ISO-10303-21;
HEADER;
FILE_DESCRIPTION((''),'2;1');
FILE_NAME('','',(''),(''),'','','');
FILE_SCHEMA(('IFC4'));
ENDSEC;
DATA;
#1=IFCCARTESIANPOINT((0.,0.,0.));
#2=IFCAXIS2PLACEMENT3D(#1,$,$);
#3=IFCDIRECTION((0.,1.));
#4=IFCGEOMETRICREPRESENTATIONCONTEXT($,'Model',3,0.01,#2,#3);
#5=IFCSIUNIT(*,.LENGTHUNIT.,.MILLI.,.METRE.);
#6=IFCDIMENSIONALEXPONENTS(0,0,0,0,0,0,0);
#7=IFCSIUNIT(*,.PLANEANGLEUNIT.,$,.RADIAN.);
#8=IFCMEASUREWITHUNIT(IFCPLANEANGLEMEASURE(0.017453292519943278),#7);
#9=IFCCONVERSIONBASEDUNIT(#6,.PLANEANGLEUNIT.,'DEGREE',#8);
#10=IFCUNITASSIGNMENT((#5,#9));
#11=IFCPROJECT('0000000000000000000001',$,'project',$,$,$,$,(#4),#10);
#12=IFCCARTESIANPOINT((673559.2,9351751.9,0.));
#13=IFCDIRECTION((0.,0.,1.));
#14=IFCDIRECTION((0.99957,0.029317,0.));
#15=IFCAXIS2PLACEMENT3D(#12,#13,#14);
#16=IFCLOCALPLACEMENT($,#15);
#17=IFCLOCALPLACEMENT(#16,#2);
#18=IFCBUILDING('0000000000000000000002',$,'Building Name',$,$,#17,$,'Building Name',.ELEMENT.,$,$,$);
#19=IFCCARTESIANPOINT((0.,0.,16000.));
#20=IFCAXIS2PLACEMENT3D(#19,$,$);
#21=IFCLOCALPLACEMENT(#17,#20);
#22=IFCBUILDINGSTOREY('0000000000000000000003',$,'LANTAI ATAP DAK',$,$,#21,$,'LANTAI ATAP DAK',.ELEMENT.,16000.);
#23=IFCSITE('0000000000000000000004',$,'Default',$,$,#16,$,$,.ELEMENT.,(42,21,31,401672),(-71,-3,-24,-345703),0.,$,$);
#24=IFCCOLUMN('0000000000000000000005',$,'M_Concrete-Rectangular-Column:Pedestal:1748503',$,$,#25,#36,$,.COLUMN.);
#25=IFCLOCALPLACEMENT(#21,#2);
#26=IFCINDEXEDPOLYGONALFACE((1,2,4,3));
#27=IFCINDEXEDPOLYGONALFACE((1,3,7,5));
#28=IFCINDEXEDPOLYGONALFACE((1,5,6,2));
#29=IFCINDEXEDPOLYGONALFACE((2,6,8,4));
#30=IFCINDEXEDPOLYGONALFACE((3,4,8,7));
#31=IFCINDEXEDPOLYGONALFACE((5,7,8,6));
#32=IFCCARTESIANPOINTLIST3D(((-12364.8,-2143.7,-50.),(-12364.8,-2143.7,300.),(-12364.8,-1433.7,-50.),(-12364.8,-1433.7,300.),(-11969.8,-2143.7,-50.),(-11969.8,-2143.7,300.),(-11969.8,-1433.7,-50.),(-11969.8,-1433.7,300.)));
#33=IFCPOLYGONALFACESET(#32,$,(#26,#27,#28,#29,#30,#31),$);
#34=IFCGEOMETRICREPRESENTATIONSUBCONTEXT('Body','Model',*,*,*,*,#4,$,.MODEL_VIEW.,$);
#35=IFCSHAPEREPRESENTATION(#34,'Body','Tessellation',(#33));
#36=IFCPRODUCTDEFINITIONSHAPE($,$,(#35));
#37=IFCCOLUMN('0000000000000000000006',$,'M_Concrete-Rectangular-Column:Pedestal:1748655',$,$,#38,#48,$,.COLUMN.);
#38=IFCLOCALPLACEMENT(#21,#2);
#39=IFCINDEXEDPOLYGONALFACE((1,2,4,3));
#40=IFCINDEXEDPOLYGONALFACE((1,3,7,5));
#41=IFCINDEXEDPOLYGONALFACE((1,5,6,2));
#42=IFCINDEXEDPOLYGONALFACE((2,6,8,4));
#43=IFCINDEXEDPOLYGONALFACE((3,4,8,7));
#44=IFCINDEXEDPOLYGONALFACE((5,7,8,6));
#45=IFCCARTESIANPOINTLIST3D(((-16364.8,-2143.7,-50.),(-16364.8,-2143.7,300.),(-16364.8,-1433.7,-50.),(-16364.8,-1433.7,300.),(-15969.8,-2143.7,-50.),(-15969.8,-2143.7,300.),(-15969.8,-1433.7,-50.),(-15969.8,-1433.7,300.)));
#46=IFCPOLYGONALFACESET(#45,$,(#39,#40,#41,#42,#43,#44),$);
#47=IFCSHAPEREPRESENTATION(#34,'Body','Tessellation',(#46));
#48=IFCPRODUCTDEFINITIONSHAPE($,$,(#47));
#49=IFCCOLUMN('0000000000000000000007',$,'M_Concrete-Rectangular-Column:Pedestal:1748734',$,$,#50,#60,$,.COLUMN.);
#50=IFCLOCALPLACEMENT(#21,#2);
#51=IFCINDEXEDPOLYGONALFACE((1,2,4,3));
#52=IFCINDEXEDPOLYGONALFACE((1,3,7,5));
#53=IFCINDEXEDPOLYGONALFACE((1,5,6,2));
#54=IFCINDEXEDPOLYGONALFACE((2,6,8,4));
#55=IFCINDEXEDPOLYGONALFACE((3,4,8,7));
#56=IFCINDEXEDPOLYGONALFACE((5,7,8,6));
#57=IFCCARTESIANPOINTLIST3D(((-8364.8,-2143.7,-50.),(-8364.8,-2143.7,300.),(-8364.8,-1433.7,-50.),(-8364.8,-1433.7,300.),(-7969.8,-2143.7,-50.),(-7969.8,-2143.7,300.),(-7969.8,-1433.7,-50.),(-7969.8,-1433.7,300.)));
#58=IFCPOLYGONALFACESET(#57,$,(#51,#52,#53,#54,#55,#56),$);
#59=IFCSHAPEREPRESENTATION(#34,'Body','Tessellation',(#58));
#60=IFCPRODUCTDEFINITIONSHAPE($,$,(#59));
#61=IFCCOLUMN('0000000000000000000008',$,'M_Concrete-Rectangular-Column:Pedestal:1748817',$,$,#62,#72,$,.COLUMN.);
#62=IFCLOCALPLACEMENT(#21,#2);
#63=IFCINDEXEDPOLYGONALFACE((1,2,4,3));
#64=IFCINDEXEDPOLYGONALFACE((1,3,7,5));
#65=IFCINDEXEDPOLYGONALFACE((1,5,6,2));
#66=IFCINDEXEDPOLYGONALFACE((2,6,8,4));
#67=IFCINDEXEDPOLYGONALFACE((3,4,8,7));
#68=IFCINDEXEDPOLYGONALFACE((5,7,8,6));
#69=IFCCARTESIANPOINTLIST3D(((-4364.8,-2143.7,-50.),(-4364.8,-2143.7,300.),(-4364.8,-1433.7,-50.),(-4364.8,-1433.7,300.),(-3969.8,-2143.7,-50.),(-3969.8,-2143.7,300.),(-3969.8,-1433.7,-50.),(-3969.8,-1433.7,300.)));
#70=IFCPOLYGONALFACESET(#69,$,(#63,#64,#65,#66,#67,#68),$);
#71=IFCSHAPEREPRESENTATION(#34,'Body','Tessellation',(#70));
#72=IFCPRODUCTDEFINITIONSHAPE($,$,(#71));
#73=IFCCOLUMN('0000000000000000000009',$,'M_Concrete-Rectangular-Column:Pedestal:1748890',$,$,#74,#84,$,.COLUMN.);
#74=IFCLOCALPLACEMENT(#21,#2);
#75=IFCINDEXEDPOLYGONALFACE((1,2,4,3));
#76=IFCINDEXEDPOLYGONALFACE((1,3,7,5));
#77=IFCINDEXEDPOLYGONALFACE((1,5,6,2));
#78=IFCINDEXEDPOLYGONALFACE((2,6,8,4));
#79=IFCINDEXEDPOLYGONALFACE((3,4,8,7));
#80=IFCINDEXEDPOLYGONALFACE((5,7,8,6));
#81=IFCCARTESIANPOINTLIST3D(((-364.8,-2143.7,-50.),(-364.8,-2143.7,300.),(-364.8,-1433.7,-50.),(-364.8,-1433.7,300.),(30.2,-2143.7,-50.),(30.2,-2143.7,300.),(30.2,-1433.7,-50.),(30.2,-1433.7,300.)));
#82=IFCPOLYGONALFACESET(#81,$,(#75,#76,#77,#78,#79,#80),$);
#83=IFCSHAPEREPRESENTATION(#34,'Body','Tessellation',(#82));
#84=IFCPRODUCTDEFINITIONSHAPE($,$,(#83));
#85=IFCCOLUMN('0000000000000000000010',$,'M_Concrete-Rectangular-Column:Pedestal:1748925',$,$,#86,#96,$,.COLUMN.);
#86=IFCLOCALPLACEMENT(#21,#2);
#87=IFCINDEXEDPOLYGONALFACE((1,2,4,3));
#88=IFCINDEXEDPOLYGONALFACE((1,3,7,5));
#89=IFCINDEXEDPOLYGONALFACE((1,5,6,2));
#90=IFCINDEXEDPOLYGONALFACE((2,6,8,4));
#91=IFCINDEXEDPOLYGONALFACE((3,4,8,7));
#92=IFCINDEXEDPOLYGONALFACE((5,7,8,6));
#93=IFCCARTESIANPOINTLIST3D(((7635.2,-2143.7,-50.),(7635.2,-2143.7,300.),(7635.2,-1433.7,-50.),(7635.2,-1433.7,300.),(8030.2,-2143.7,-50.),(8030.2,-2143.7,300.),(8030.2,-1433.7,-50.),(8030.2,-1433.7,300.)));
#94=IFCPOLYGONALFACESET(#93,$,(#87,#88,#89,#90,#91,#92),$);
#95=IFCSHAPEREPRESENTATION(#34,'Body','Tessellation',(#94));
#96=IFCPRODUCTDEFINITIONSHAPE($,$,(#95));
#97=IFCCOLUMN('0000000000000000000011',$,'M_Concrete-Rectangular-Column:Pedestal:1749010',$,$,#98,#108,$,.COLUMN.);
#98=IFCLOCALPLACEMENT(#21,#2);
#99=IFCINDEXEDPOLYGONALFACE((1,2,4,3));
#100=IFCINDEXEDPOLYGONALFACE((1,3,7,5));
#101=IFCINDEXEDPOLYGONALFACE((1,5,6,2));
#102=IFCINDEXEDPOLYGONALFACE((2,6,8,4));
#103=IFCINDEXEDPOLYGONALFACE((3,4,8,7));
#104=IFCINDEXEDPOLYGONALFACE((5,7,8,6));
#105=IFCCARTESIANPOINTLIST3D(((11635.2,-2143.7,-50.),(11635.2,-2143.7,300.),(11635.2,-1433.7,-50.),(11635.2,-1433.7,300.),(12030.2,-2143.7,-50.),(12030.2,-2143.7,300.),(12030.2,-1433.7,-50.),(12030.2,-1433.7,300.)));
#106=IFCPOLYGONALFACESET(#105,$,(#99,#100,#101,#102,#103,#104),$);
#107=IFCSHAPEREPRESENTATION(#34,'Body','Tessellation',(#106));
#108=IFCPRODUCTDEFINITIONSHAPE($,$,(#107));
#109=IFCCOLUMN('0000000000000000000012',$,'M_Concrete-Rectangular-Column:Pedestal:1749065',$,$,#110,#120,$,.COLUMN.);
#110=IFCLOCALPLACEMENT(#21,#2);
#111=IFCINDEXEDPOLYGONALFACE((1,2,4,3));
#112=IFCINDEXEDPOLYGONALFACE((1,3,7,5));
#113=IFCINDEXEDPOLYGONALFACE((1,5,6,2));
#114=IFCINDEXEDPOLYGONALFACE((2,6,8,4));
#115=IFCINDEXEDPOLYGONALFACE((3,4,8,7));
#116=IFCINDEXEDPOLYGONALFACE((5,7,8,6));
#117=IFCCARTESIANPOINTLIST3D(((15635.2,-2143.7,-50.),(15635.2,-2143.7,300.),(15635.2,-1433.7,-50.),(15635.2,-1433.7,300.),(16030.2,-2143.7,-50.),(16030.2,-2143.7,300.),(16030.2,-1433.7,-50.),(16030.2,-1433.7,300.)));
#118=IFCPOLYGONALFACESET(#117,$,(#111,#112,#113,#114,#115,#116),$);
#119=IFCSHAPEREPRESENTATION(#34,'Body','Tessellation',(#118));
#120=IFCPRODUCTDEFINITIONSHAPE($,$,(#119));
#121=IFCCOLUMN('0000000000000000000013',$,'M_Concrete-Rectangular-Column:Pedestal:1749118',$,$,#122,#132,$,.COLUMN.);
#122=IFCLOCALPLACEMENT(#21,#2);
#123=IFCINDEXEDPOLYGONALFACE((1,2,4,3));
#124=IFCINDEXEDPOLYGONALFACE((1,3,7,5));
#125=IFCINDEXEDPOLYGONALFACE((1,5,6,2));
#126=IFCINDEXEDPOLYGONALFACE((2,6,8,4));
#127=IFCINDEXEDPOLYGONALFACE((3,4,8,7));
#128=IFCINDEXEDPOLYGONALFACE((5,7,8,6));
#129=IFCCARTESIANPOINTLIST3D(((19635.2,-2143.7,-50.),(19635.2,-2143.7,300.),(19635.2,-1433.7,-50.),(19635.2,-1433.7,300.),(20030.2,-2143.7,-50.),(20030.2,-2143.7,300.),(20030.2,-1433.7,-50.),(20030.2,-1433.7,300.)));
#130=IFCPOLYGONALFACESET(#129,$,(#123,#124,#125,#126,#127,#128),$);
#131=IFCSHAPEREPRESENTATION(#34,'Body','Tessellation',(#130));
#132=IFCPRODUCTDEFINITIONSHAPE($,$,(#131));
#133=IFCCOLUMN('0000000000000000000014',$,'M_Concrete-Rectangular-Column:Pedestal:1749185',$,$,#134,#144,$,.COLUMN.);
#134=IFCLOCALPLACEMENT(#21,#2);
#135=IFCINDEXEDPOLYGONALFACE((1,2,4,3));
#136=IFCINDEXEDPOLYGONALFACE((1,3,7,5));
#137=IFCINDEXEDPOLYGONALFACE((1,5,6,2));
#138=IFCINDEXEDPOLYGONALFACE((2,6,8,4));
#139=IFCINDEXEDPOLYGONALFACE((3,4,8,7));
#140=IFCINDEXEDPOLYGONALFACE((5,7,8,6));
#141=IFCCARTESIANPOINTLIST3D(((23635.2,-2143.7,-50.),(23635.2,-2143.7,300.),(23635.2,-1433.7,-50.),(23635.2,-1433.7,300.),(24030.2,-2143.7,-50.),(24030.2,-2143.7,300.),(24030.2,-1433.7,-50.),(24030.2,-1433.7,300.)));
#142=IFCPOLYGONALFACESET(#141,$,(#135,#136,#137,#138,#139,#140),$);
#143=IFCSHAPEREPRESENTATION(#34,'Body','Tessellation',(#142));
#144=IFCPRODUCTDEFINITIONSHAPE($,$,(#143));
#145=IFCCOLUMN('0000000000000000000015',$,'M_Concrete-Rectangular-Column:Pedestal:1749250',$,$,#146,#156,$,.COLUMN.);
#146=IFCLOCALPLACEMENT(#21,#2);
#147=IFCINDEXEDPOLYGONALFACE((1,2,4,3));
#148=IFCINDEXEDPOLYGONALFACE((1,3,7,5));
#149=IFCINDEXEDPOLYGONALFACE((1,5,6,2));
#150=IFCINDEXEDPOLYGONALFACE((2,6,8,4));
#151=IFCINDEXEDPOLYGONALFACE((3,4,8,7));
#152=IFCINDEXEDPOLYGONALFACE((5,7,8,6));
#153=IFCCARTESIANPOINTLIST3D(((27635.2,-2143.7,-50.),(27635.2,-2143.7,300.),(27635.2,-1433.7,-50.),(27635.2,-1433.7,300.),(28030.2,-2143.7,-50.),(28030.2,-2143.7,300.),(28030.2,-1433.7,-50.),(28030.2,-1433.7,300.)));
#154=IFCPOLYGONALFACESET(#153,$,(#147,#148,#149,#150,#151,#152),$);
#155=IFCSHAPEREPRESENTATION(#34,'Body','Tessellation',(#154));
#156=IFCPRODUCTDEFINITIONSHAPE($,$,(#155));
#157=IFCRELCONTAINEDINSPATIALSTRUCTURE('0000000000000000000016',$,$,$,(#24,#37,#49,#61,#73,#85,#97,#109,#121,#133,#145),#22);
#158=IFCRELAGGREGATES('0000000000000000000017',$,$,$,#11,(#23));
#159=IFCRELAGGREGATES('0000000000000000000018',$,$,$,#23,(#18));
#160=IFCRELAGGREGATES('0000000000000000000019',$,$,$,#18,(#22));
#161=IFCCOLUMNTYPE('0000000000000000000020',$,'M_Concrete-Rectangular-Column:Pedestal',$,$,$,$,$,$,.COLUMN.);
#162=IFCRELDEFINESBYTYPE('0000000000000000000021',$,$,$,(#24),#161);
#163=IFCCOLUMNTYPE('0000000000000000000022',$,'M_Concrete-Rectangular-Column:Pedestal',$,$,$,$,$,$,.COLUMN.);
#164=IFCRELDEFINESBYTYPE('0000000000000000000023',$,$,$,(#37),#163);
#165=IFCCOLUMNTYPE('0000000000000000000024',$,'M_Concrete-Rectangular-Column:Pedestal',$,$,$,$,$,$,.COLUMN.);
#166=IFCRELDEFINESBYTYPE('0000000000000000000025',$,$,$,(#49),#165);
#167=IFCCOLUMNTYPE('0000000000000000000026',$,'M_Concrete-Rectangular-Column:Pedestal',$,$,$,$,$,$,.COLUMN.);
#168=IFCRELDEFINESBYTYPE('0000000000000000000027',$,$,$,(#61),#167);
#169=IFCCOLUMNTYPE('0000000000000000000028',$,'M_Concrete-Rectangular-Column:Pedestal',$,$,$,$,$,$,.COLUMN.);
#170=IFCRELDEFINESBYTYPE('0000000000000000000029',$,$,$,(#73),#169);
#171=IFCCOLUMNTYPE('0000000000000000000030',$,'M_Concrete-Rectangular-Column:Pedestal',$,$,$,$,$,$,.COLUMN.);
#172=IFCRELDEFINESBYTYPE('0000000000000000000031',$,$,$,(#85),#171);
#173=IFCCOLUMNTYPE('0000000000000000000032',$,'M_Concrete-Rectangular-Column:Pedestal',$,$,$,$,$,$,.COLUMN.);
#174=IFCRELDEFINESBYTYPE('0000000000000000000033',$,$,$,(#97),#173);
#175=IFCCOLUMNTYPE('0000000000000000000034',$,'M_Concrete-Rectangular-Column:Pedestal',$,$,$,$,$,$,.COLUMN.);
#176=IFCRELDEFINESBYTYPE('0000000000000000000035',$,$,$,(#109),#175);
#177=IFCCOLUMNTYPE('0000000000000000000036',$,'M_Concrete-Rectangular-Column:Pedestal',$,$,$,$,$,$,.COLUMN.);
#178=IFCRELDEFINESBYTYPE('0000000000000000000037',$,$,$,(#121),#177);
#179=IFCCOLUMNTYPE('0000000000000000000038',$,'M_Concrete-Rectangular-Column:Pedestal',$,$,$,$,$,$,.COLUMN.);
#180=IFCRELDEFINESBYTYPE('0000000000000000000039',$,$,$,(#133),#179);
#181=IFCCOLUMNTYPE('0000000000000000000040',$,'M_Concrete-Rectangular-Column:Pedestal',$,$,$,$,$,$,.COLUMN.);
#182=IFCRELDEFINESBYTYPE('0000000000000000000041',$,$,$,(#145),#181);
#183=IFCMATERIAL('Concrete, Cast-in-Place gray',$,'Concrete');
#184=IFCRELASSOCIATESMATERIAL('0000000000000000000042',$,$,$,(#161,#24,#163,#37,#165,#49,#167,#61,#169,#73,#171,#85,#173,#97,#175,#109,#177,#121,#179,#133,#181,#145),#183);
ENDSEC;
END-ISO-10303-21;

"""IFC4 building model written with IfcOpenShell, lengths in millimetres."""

from ifc_helpers import new_model, entity, si_unit, converted_unit, direction, frame, origin, place, context, subcontext, project, spatial, indexed_curve, outline, extrude, source, transform, mapped, material, type_object, type_shapes, element, save


model = new_model("IFC4")

# Units and contexts
model_context = context("Model", 3, precision=0.01, world=origin(), true_north=direction((0.0, 1.0)))
body_context = subcontext(model_context, "Body", "Model", "MODEL_VIEW")
ifc_project = project(units=[si_unit("LENGTHUNIT", "METRE", prefix="MILLI"), converted_unit("PLANEANGLEUNIT", "DEGREE", entity("IfcPlaneAngleMeasure", 0.017453292519943278), si_unit("PLANEANGLEUNIT", "RADIAN"), dimensions=[0, 0, 0, 0, 0, 0, 0])], contexts=[model_context])

# Site, building, storey
site_placement = place(None, frame((673559.2, 9351751.9, 0.0), z_axis=(0.0, 0.0, 1.0), x_axis=(0.99957, 0.029317, 0.0)))
site = spatial("IfcSite", under=ifc_project, at=site_placement, Name="Default", CompositionType="ELEMENT", RefLatitude=(42, 21, 31, 401672), RefLongitude=(-71, -3, -24, -345703), RefElevation=0.0)
building_placement = place(site_placement, origin())
building = spatial("IfcBuilding", under=site, at=building_placement, Name="Building Name", LongName="Building Name", CompositionType="ELEMENT")
storey_placement = place(building_placement, frame((0.0, 0.0, 16000.0)))
storey = spatial("IfcBuildingStorey", under=building, at=storey_placement, Name="LANTAI ATAP DAK", LongName="LANTAI ATAP DAK", CompositionType="ELEMENT", Elevation=16000.0)

# Columns
ifc_material = material(Name="Concrete, Cast-in-Place gray", Category="Concrete")
column_type_1 = type_object("IfcColumnType", Name="M_Concrete-Rectangular-Column:Pedestal", PredefinedType="COLUMN", material=ifc_material)
shared_shape_1 = source(origin(), body_context, "Body", "SweptSolid", [
    extrude(outline(indexed_curve([(-197.5, -355.0), (197.5, -355.0), (197.5, 355.0), (-197.5, 355.0), (-197.5, -355.0)], self_intersect=False)), frame((-12167.3, -1788.7, 15950.0), z_axis=(0.0, 0.0, 1.0), x_axis=(-1.0, 0.0, 0.0)), (0.0, 0.0, 1.0), 350.0),
])
type_shapes(column_type_1, [shared_shape_1])
column_1_placement = place(storey_placement, frame((0.0, 0.0, -16000.0)))
element("IfcColumn", 1, at=column_1_placement, inside=storey, type_object=column_type_1, material=ifc_material, Name="M_Concrete-Rectangular-Column:Pedestal:1748503", PredefinedType="COLUMN", context=body_context, shape_type="MappedRepresentation", body=[
    mapped(shared_shape_1, transform((0.0, 0.0, 0.0), scale=1.0)),
])
column_type_2 = type_object("IfcColumnType", Name="M_Concrete-Rectangular-Column:Pedestal", PredefinedType="COLUMN", material=ifc_material)
shared_shape_2 = source(origin(), body_context, "Body", "SweptSolid", [
    extrude(outline(indexed_curve([(-197.5, -355.0), (197.5, -355.0), (197.5, 355.0), (-197.5, 355.0), (-197.5, -355.0)], self_intersect=False)), frame((-16167.3, -1788.7, 15950.0), z_axis=(0.0, 0.0, 1.0), x_axis=(-1.0, 0.0, 0.0)), (0.0, 0.0, 1.0), 350.0),
])
type_shapes(column_type_2, [shared_shape_2])
column_2_placement = place(storey_placement, frame((0.0, 0.0, -16000.0)))
element("IfcColumn", 2, at=column_2_placement, inside=storey, type_object=column_type_2, material=ifc_material, Name="M_Concrete-Rectangular-Column:Pedestal:1748655", PredefinedType="COLUMN", context=body_context, shape_type="MappedRepresentation", body=[
    mapped(shared_shape_2, transform((0.0, 0.0, 0.0), scale=1.0)),
])
column_type_3 = type_object("IfcColumnType", Name="M_Concrete-Rectangular-Column:Pedestal", PredefinedType="COLUMN", material=ifc_material)
shared_shape_3 = source(origin(), body_context, "Body", "SweptSolid", [
    extrude(outline(indexed_curve([(-197.5, -355.0), (197.5, -355.0), (197.5, 355.0), (-197.5, 355.0), (-197.5, -355.0)], self_intersect=False)), frame((-8167.3, -1788.7, 15950.0), z_axis=(0.0, 0.0, 1.0), x_axis=(-1.0, 0.0, 0.0)), (0.0, 0.0, 1.0), 350.0),
])
type_shapes(column_type_3, [shared_shape_3])
column_3_placement = place(storey_placement, frame((0.0, 0.0, -16000.0)))
element("IfcColumn", 3, at=column_3_placement, inside=storey, type_object=column_type_3, material=ifc_material, Name="M_Concrete-Rectangular-Column:Pedestal:1748734", PredefinedType="COLUMN", context=body_context, shape_type="MappedRepresentation", body=[
    mapped(shared_shape_3, transform((0.0, 0.0, 0.0), scale=1.0)),
])
column_type_4 = type_object("IfcColumnType", Name="M_Concrete-Rectangular-Column:Pedestal", PredefinedType="COLUMN", material=ifc_material)
shared_shape_4 = source(origin(), body_context, "Body", "SweptSolid", [
    extrude(outline(indexed_curve([(-197.5, -355.0), (197.5, -355.0), (197.5, 355.0), (-197.5, 355.0), (-197.5, -355.0)], self_intersect=False)), frame((-4167.3, -1788.7, 15950.0), z_axis=(0.0, 0.0, 1.0), x_axis=(-1.0, 0.0, 0.0)), (0.0, 0.0, 1.0), 350.0),
])
type_shapes(column_type_4, [shared_shape_4])
column_4_placement = place(storey_placement, frame((0.0, 0.0, -16000.0)))
element("IfcColumn", 4, at=column_4_placement, inside=storey, type_object=column_type_4, material=ifc_material, Name="M_Concrete-Rectangular-Column:Pedestal:1748817", PredefinedType="COLUMN", context=body_context, shape_type="MappedRepresentation", body=[
    mapped(shared_shape_4, transform((0.0, 0.0, 0.0), scale=1.0)),
])
column_type_5 = type_object("IfcColumnType", Name="M_Concrete-Rectangular-Column:Pedestal", PredefinedType="COLUMN", material=ifc_material)
shared_shape_5 = source(origin(), body_context, "Body", "SweptSolid", [
    extrude(outline(indexed_curve([(-197.5, -355.0), (197.5, -355.0), (197.5, 355.0), (-197.5, 355.0), (-197.5, -355.0)], self_intersect=False)), frame((-167.3, -1788.7, 15950.0), z_axis=(0.0, 0.0, 1.0), x_axis=(-1.0, 0.0, 0.0)), (0.0, 0.0, 1.0), 350.0),
])
type_shapes(column_type_5, [shared_shape_5])
column_5_placement = place(storey_placement, frame((0.0, 0.0, -16000.0)))
element("IfcColumn", 5, at=column_5_placement, inside=storey, type_object=column_type_5, material=ifc_material, Name="M_Concrete-Rectangular-Column:Pedestal:1748890", PredefinedType="COLUMN", context=body_context, shape_type="MappedRepresentation", body=[
    mapped(shared_shape_5, transform((0.0, 0.0, 0.0), scale=1.0)),
])
column_type_6 = type_object("IfcColumnType", Name="M_Concrete-Rectangular-Column:Pedestal", PredefinedType="COLUMN", material=ifc_material)
shared_shape_6 = source(origin(), body_context, "Body", "SweptSolid", [
    extrude(outline(indexed_curve([(-197.5, -355.0), (197.5, -355.0), (197.5, 355.0), (-197.5, 355.0), (-197.5, -355.0)], self_intersect=False)), frame((7832.7, -1788.7, 15950.0), z_axis=(0.0, 0.0, 1.0), x_axis=(-1.0, 0.0, 0.0)), (0.0, 0.0, 1.0), 350.0),
])
type_shapes(column_type_6, [shared_shape_6])
column_6_placement = place(storey_placement, frame((0.0, 0.0, -16000.0)))
element("IfcColumn", 6, at=column_6_placement, inside=storey, type_object=column_type_6, material=ifc_material, Name="M_Concrete-Rectangular-Column:Pedestal:1748925", PredefinedType="COLUMN", context=body_context, shape_type="MappedRepresentation", body=[
    mapped(shared_shape_6, transform((0.0, 0.0, 0.0), scale=1.0)),
])
column_type_7 = type_object("IfcColumnType", Name="M_Concrete-Rectangular-Column:Pedestal", PredefinedType="COLUMN", material=ifc_material)
shared_shape_7 = source(origin(), body_context, "Body", "SweptSolid", [
    extrude(outline(indexed_curve([(-197.5, -355.0), (197.5, -355.0), (197.5, 355.0), (-197.5, 355.0), (-197.5, -355.0)], self_intersect=False)), frame((11832.7, -1788.7, 15950.0), z_axis=(0.0, 0.0, 1.0), x_axis=(-1.0, 0.0, 0.0)), (0.0, 0.0, 1.0), 350.0),
])
type_shapes(column_type_7, [shared_shape_7])
column_7_placement = place(storey_placement, frame((0.0, 0.0, -16000.0)))
element("IfcColumn", 7, at=column_7_placement, inside=storey, type_object=column_type_7, material=ifc_material, Name="M_Concrete-Rectangular-Column:Pedestal:1749010", PredefinedType="COLUMN", context=body_context, shape_type="MappedRepresentation", body=[
    mapped(shared_shape_7, transform((0.0, 0.0, 0.0), scale=1.0)),
])
column_type_8 = type_object("IfcColumnType", Name="M_Concrete-Rectangular-Column:Pedestal", PredefinedType="COLUMN", material=ifc_material)
shared_shape_8 = source(origin(), body_context, "Body", "SweptSolid", [
    extrude(outline(indexed_curve([(-197.5, -355.0), (197.5, -355.0), (197.5, 355.0), (-197.5, 355.0), (-197.5, -355.0)], self_intersect=False)), frame((15832.7, -1788.7, 15950.0), z_axis=(0.0, 0.0, 1.0), x_axis=(-1.0, 0.0, 0.0)), (0.0, 0.0, 1.0), 350.0),
])
type_shapes(column_type_8, [shared_shape_8])
column_8_placement = place(storey_placement, frame((0.0, 0.0, -16000.0)))
element("IfcColumn", 8, at=column_8_placement, inside=storey, type_object=column_type_8, material=ifc_material, Name="M_Concrete-Rectangular-Column:Pedestal:1749065", PredefinedType="COLUMN", context=body_context, shape_type="MappedRepresentation", body=[
    mapped(shared_shape_8, transform((0.0, 0.0, 0.0), scale=1.0)),
])
column_type_9 = type_object("IfcColumnType", Name="M_Concrete-Rectangular-Column:Pedestal", PredefinedType="COLUMN", material=ifc_material)
shared_shape_9 = source(origin(), body_context, "Body", "SweptSolid", [
    extrude(outline(indexed_curve([(-197.5, -355.0), (197.5, -355.0), (197.5, 355.0), (-197.5, 355.0), (-197.5, -355.0)], self_intersect=False)), frame((19832.7, -1788.7, 15950.0), z_axis=(0.0, 0.0, 1.0), x_axis=(-1.0, 0.0, 0.0)), (0.0, 0.0, 1.0), 350.0),
])
type_shapes(column_type_9, [shared_shape_9])
column_9_placement = place(storey_placement, frame((0.0, 0.0, -16000.0)))
element("IfcColumn", 9, at=column_9_placement, inside=storey, type_object=column_type_9, material=ifc_material, Name="M_Concrete-Rectangular-Column:Pedestal:1749118", PredefinedType="COLUMN", context=body_context, shape_type="MappedRepresentation", body=[
    mapped(shared_shape_9, transform((0.0, 0.0, 0.0), scale=1.0)),
])
column_type_10 = type_object("IfcColumnType", Name="M_Concrete-Rectangular-Column:Pedestal", PredefinedType="COLUMN", material=ifc_material)
shared_shape_10 = source(origin(), body_context, "Body", "SweptSolid", [
    extrude(outline(indexed_curve([(-197.5, -355.0), (197.5, -355.0), (197.5, 355.0), (-197.5, 355.0), (-197.5, -355.0)], self_intersect=False)), frame((23832.7, -1788.7, 15950.0), z_axis=(0.0, 0.0, 1.0), x_axis=(-1.0, 0.0, 0.0)), (0.0, 0.0, 1.0), 350.0),
])
type_shapes(column_type_10, [shared_shape_10])
column_10_placement = place(storey_placement, frame((0.0, 0.0, -16000.0)))
element("IfcColumn", 10, at=column_10_placement, inside=storey, type_object=column_type_10, material=ifc_material, Name="M_Concrete-Rectangular-Column:Pedestal:1749185", PredefinedType="COLUMN", context=body_context, shape_type="MappedRepresentation", body=[
    mapped(shared_shape_10, transform((0.0, 0.0, 0.0), scale=1.0)),
])
column_type_11 = type_object("IfcColumnType", Name="M_Concrete-Rectangular-Column:Pedestal", PredefinedType="COLUMN", material=ifc_material)
shared_shape_11 = source(origin(), body_context, "Body", "SweptSolid", [
    extrude(outline(indexed_curve([(-197.5, -355.0), (197.5, -355.0), (197.5, 355.0), (-197.5, 355.0), (-197.5, -355.0)], self_intersect=False)), frame((27832.7, -1788.7, 15950.0), z_axis=(0.0, 0.0, 1.0), x_axis=(-1.0, 0.0, 0.0)), (0.0, 0.0, 1.0), 350.0),
])
type_shapes(column_type_11, [shared_shape_11])
column_11_placement = place(storey_placement, frame((0.0, 0.0, -16000.0)))
element("IfcColumn", 11, at=column_11_placement, inside=storey, type_object=column_type_11, material=ifc_material, Name="M_Concrete-Rectangular-Column:Pedestal:1749250", PredefinedType="COLUMN", context=body_context, shape_type="MappedRepresentation", body=[
    mapped(shared_shape_11, transform((0.0, 0.0, 0.0), scale=1.0)),
])

save(model, "model.ifc")
